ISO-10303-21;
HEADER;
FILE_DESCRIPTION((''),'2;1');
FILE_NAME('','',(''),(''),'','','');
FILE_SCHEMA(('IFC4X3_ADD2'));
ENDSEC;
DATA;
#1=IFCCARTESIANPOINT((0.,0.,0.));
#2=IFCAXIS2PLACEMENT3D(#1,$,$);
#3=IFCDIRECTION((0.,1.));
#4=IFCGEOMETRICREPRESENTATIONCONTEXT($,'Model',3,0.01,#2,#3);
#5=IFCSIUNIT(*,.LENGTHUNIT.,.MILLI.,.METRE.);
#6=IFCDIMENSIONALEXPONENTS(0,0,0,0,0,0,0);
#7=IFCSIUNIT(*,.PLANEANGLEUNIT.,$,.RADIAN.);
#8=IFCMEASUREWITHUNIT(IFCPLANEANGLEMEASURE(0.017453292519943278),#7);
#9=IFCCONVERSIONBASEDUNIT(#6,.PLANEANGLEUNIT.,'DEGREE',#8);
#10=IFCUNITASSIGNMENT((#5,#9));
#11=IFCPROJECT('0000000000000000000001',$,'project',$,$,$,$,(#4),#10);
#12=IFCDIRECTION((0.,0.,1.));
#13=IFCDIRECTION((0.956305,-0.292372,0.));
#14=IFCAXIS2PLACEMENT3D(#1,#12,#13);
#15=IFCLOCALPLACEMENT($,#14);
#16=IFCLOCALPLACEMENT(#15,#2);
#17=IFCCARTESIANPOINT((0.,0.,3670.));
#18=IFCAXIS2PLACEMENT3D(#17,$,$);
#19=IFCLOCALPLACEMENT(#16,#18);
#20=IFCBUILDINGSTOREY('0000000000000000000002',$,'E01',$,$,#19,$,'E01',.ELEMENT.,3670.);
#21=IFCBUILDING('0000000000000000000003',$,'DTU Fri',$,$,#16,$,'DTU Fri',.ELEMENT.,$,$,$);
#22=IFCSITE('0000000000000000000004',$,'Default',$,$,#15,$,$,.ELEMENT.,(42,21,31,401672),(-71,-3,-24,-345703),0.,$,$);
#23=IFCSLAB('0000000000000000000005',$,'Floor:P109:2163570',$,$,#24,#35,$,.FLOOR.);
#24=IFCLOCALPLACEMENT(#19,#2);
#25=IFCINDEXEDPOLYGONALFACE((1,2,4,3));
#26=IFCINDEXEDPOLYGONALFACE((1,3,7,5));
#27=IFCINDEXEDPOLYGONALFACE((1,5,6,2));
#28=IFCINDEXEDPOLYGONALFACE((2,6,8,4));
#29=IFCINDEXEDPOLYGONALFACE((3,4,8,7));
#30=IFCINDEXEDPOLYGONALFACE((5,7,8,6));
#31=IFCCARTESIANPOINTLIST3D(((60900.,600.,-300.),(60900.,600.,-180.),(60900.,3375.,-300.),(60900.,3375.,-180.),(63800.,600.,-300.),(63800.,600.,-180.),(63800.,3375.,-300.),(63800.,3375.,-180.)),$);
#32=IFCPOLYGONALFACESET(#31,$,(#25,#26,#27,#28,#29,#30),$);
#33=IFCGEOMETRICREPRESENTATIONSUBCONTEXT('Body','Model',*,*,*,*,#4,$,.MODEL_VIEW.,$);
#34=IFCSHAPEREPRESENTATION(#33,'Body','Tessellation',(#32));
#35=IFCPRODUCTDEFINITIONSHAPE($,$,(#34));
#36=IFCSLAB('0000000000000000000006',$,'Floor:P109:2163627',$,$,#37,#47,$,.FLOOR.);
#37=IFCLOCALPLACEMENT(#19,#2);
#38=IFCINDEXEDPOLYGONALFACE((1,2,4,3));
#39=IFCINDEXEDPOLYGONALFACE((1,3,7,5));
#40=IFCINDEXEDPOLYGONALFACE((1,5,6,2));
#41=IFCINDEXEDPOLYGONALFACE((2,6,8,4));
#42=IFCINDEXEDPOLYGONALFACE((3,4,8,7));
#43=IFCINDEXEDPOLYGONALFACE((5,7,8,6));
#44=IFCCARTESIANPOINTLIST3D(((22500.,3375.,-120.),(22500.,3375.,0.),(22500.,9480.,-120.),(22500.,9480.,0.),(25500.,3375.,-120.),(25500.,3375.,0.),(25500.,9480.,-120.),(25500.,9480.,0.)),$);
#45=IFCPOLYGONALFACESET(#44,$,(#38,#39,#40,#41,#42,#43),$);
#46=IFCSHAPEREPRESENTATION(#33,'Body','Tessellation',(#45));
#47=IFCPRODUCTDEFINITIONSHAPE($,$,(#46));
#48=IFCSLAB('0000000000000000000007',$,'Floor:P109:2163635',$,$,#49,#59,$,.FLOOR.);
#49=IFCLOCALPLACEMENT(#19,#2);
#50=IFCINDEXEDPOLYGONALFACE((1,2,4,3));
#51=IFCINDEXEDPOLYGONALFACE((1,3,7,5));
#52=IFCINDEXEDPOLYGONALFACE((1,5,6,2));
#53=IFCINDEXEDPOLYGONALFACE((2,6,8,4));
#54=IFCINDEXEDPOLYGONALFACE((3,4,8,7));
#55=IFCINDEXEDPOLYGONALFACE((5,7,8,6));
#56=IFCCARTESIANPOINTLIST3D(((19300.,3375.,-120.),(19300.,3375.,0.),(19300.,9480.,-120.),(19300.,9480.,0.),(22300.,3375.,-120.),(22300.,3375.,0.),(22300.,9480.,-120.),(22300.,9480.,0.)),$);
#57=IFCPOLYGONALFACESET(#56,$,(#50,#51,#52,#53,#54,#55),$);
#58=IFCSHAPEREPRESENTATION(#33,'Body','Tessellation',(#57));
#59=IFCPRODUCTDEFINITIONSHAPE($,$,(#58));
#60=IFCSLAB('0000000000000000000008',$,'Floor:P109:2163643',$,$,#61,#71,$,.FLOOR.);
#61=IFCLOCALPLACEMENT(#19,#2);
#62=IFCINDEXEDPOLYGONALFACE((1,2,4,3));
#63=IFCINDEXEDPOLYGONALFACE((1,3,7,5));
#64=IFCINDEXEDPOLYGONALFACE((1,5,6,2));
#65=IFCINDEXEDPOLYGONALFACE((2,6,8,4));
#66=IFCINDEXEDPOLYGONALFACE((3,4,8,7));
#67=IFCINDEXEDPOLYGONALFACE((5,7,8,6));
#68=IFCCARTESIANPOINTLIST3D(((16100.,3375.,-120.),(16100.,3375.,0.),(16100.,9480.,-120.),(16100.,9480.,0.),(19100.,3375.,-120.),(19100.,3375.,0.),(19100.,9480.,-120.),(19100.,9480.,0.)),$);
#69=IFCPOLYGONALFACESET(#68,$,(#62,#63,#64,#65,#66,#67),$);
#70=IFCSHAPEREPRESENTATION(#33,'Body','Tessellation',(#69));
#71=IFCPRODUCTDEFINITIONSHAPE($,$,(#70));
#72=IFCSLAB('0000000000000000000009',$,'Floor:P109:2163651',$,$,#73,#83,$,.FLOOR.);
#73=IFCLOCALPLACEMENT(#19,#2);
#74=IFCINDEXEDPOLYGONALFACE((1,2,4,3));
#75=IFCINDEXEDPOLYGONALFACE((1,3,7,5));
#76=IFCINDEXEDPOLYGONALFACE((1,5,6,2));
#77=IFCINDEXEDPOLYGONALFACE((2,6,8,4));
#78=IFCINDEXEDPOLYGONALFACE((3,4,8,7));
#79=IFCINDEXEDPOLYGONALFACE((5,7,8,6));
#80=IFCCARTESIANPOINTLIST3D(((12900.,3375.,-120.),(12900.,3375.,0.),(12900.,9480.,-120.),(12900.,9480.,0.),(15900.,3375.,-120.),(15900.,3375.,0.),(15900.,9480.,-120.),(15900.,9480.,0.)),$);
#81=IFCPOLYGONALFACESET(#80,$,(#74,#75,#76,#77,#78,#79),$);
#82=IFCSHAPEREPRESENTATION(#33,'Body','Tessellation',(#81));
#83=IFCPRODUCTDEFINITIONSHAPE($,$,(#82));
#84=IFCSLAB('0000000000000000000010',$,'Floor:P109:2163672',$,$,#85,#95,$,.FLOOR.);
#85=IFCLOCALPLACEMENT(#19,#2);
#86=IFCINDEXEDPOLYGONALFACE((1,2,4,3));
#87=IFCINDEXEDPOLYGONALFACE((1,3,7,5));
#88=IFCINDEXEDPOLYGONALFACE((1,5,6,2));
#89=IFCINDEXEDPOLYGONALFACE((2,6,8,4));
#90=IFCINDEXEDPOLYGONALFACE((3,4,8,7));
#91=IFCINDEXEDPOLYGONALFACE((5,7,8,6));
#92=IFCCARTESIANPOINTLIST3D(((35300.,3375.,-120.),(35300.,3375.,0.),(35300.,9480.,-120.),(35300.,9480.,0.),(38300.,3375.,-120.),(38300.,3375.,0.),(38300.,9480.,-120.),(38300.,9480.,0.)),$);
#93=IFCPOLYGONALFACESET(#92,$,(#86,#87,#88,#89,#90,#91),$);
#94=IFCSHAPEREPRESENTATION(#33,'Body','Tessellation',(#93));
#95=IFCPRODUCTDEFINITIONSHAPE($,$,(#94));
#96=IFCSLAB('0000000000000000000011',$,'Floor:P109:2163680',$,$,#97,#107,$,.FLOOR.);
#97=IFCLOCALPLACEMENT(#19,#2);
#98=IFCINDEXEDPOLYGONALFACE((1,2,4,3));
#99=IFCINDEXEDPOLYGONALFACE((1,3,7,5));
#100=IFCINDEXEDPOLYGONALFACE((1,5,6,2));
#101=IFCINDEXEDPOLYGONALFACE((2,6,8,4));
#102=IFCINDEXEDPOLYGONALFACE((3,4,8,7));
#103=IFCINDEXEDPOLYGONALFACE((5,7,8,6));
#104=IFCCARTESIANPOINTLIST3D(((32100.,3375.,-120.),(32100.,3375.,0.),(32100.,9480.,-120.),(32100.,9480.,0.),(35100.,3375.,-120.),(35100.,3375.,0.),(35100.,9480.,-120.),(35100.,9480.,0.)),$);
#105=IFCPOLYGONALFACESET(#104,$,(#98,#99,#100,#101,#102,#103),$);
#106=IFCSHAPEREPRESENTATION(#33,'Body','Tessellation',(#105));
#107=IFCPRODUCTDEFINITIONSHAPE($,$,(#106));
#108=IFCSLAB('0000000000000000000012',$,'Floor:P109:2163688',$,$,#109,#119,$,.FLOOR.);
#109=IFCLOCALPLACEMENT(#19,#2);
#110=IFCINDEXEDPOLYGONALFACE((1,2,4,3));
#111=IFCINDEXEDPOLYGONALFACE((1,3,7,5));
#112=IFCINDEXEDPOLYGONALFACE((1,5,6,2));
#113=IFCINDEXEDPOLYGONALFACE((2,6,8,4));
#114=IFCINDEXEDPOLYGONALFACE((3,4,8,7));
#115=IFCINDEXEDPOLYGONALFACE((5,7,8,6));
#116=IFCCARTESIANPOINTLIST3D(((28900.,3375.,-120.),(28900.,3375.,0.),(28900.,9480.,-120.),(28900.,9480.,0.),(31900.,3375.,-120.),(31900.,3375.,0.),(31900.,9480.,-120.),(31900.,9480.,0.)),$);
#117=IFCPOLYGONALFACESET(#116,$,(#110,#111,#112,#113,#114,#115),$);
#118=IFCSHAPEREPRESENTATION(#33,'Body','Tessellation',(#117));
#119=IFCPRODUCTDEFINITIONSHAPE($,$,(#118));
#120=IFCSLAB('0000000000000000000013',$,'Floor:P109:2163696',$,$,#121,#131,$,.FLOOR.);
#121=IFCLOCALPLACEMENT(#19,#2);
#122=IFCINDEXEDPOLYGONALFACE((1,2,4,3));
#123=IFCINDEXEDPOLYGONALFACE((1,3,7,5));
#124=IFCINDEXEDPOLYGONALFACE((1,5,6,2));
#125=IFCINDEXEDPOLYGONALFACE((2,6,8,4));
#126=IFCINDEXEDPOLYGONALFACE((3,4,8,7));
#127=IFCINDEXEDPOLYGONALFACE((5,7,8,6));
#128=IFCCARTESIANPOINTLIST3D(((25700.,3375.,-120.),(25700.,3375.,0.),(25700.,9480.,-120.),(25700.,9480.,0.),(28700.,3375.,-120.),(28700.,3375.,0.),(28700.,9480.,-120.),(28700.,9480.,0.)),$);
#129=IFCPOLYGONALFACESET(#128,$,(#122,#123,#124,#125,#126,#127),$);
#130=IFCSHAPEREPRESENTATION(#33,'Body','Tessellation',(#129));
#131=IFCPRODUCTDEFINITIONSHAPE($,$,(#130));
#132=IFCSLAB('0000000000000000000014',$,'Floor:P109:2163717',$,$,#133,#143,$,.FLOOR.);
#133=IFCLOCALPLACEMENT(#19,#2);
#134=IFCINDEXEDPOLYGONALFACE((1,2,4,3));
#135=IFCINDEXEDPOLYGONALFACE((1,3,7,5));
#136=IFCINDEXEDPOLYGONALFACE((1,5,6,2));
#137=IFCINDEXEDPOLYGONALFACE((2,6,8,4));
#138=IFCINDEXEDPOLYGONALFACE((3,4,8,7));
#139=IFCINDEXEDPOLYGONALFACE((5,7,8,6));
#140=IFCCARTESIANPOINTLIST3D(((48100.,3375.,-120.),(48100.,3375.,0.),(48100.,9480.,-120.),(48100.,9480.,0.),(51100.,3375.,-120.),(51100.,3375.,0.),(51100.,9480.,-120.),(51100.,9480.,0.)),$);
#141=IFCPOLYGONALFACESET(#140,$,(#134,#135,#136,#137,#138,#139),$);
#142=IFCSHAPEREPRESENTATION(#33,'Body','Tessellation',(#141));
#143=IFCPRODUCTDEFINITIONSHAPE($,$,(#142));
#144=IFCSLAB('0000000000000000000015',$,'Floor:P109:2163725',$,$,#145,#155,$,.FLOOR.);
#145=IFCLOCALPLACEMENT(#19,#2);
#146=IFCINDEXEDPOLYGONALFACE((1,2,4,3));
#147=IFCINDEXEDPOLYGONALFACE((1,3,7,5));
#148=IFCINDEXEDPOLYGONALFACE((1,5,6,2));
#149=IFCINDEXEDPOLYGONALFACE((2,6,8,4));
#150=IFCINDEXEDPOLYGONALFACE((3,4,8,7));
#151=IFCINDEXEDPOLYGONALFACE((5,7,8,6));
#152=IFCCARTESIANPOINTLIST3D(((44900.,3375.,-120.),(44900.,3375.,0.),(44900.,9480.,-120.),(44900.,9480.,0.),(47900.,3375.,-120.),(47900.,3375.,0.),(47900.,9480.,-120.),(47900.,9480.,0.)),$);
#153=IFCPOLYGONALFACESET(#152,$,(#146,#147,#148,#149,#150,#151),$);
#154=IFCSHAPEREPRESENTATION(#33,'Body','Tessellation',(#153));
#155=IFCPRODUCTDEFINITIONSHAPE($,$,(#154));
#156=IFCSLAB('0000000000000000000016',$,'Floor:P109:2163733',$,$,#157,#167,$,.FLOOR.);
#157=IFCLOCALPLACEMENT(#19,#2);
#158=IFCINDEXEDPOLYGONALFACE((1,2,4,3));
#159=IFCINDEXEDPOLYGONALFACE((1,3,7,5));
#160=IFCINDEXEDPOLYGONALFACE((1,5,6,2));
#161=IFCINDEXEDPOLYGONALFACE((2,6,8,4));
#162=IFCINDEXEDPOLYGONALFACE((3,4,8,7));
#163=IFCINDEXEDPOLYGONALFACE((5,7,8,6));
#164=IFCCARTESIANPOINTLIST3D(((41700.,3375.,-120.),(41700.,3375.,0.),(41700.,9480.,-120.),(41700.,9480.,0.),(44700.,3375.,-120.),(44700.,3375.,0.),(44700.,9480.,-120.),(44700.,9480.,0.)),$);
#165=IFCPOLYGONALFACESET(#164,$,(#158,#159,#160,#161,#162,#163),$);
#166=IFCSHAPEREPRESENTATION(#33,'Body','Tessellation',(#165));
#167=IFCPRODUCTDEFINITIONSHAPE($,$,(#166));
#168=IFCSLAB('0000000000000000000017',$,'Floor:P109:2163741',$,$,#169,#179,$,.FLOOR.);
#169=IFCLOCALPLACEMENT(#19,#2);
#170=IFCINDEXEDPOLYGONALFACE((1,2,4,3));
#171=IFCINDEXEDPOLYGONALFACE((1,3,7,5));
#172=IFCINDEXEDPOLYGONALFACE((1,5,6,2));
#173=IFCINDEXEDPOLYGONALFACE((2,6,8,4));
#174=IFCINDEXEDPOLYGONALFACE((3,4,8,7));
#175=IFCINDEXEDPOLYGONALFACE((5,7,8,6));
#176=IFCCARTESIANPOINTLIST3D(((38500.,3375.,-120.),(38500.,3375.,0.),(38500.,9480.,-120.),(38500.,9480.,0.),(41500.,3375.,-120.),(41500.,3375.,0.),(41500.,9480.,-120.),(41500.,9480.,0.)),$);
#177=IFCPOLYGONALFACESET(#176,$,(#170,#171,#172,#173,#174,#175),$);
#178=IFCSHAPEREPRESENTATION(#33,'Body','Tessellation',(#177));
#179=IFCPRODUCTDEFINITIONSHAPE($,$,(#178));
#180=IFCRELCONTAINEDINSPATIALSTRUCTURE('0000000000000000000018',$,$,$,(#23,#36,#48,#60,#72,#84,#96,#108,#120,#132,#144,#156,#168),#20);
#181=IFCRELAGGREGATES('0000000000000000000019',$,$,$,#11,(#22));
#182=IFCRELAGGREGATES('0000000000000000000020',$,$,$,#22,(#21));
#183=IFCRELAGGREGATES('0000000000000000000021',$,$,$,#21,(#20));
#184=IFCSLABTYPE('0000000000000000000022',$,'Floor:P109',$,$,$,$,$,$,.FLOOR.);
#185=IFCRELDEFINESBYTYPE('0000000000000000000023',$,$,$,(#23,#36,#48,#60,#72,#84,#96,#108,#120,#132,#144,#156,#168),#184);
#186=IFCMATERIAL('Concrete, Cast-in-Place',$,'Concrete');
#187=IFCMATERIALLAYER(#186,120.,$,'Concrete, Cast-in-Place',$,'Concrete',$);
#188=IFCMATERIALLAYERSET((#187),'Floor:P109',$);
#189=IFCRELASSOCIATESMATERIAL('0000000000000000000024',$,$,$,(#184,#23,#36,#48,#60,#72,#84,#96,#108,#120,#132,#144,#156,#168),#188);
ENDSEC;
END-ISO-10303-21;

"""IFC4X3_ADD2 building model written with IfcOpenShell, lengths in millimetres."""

from ifc_helpers import new_model, entity, si_unit, converted_unit, direction, frame, frame_2d, origin, origin_2d_with_axis, place, context, subcontext, project, spatial, rectangle, extrude, material, layer, layer_set, layer_usage, type_object, element, save


model = new_model("IFC4X3_ADD2")

# Units and contexts
model_context = context("Model", 3, precision=0.01, world=origin(), true_north=direction((0.0, 1.0)))
body_context = subcontext(model_context, "Body", "Model", "MODEL_VIEW")
ifc_project = project(units=[si_unit("LENGTHUNIT", "METRE", prefix="MILLI"), converted_unit("PLANEANGLEUNIT", "DEGREE", entity("IfcPlaneAngleMeasure", 0.017453292519943278), si_unit("PLANEANGLEUNIT", "RADIAN"), dimensions=[0, 0, 0, 0, 0, 0, 0])], contexts=[model_context])

# Site, building, storey
site_placement = place(None, frame((0.0, 0.0, 0.0), z_axis=(0.0, 0.0, 1.0), x_axis=(0.956305, -0.292372, 0.0)))
site = spatial("IfcSite", under=ifc_project, at=site_placement, Name="Default", CompositionType="ELEMENT", RefLatitude=(42, 21, 31, 401672), RefLongitude=(-71, -3, -24, -345703), RefElevation=0.0)
building_placement = place(site_placement, origin())
building = spatial("IfcBuilding", under=site, at=building_placement, Name="DTU Fri", LongName="DTU Fri", CompositionType="ELEMENT")
storey_placement = place(building_placement, frame((0.0, 0.0, 3670.0)))
storey = spatial("IfcBuildingStorey", under=building, at=storey_placement, Name="E01", LongName="E01", CompositionType="ELEMENT", Elevation=3670.0)

# Slabs
ifc_material = material(Name="Concrete, Cast-in-Place", Category="Concrete")
ifc_layer_1 = layer(ifc_material, 120.0, Name="Concrete, Cast-in-Place", Category="Concrete")
ifc_layer_set_1 = layer_set([ifc_layer_1], Name="Floor:P109")
slab_type_1 = type_object("IfcSlabType", Name="Floor:P109", PredefinedType="FLOOR", material=ifc_layer_set_1)
ifc_layer_usage_1 = layer_usage(ifc_layer_set_1, "AXIS3", "POSITIVE", 0.0)
slab_1_placement = place(storey_placement, origin())
element("IfcSlab", 1, at=slab_1_placement, inside=storey, type_object=slab_type_1, material=ifc_layer_usage_1, Name="Floor:P109:2163570", PredefinedType="FLOOR", context=body_context, shape_type="SweptSolid", body=[
    extrude(rectangle(XDim=2775.0, YDim=2900.0, at=frame_2d((0.0, 0.0), x_axis=(1.0, 0.0))), frame((62350.0, 1987.5, -180.0), z_axis=(0.0, 0.0, -1.0), x_axis=(0.0, 1.0, 0.0)), (0.0, 0.0, 1.0), 120.0),
])
ifc_layer_usage_2 = layer_usage(ifc_layer_set_1, "AXIS3", "POSITIVE", 0.0)
slab_2_placement = place(storey_placement, origin())
element("IfcSlab", 2, at=slab_2_placement, inside=storey, type_object=slab_type_1, material=ifc_layer_usage_2, Name="Floor:P109:2163627", PredefinedType="FLOOR", context=body_context, shape_type="SweptSolid", body=[
    extrude(rectangle(XDim=6105.0, YDim=3000.0, at=frame_2d((0.0, 0.0), x_axis=(1.0, 0.0))), frame((24000.0, 6427.5, 0.0), z_axis=(0.0, 0.0, -1.0), x_axis=(0.0, 1.0, 0.0)), (0.0, 0.0, 1.0), 120.0),
])
ifc_layer_usage_3 = layer_usage(ifc_layer_set_1, "AXIS3", "POSITIVE", 0.0)
slab_3_placement = place(storey_placement, origin())
element("IfcSlab", 3, at=slab_3_placement, inside=storey, type_object=slab_type_1, material=ifc_layer_usage_3, Name="Floor:P109:2163635", PredefinedType="FLOOR", context=body_context, shape_type="SweptSolid", body=[
    extrude(rectangle(XDim=6105.0, YDim=3000.0, at=frame_2d((0.0, 0.0), x_axis=(1.0, 0.0))), frame((20800.0, 6427.5, 0.0), z_axis=(0.0, 0.0, -1.0), x_axis=(0.0, 1.0, 0.0)), (0.0, 0.0, 1.0), 120.0),
])
ifc_layer_usage_4 = layer_usage(ifc_layer_set_1, "AXIS3", "POSITIVE", 0.0)
slab_4_placement = place(storey_placement, origin())
element("IfcSlab", 4, at=slab_4_placement, inside=storey, type_object=slab_type_1, material=ifc_layer_usage_4, Name="Floor:P109:2163643", PredefinedType="FLOOR", context=body_context, shape_type="SweptSolid", body=[
    extrude(rectangle(XDim=6105.0, YDim=3000.0, at=frame_2d((0.0, 0.0), x_axis=(1.0, 0.0))), frame((17600.0, 6427.5, 0.0), z_axis=(0.0, 0.0, -1.0), x_axis=(0.0, 1.0, 0.0)), (0.0, 0.0, 1.0), 120.0),
])
ifc_layer_usage_5 = layer_usage(ifc_layer_set_1, "AXIS3", "POSITIVE", 0.0)
slab_5_placement = place(storey_placement, origin())
element("IfcSlab", 5, at=slab_5_placement, inside=storey, type_object=slab_type_1, material=ifc_layer_usage_5, Name="Floor:P109:2163651", PredefinedType="FLOOR", context=body_context, shape_type="SweptSolid", body=[
    extrude(rectangle(XDim=6105.0, YDim=3000.0, at=frame_2d((0.0, 0.0), x_axis=(1.0, 0.0))), frame((14400.0, 6427.5, 0.0), z_axis=(0.0, 0.0, -1.0), x_axis=(0.0, 1.0, 0.0)), (0.0, 0.0, 1.0), 120.0),
])
ifc_layer_usage_6 = layer_usage(ifc_layer_set_1, "AXIS3", "POSITIVE", 0.0)
slab_6_placement = place(storey_placement, origin())
element("IfcSlab", 6, at=slab_6_placement, inside=storey, type_object=slab_type_1, material=ifc_layer_usage_6, Name="Floor:P109:2163672", PredefinedType="FLOOR", context=body_context, shape_type="SweptSolid", body=[
    extrude(rectangle(XDim=6105.0, YDim=3000.0, at=frame_2d((0.0, 0.0), x_axis=(1.0, 0.0))), frame((36800.0, 6427.5, 0.0), z_axis=(0.0, 0.0, -1.0), x_axis=(0.0, 1.0, 0.0)), (0.0, 0.0, 1.0), 120.0),
])
ifc_layer_usage_7 = layer_usage(ifc_layer_set_1, "AXIS3", "POSITIVE", 0.0)
slab_7_placement = place(storey_placement, origin())
element("IfcSlab", 7, at=slab_7_placement, inside=storey, type_object=slab_type_1, material=ifc_layer_usage_7, Name="Floor:P109:2163680", PredefinedType="FLOOR", context=body_context, shape_type="SweptSolid", body=[
    extrude(rectangle(XDim=6105.0, YDim=3000.0, at=frame_2d((0.0, 0.0), x_axis=(1.0, 0.0))), frame((33600.0, 6427.5, 0.0), z_axis=(0.0, 0.0, -1.0), x_axis=(0.0, 1.0, 0.0)), (0.0, 0.0, 1.0), 120.0),
])
ifc_layer_usage_8 = layer_usage(ifc_layer_set_1, "AXIS3", "POSITIVE", 0.0)
slab_8_placement = place(storey_placement, origin())
element("IfcSlab", 8, at=slab_8_placement, inside=storey, type_object=slab_type_1, material=ifc_layer_usage_8, Name="Floor:P109:2163688", PredefinedType="FLOOR", context=body_context, shape_type="SweptSolid", body=[
    extrude(rectangle(XDim=6105.0, YDim=3000.0, at=frame_2d((0.0, 0.0), x_axis=(1.0, 0.0))), frame((30400.0, 6427.5, 0.0), z_axis=(0.0, 0.0, -1.0), x_axis=(0.0, 1.0, 0.0)), (0.0, 0.0, 1.0), 120.0),
])
ifc_layer_usage_9 = layer_usage(ifc_layer_set_1, "AXIS3", "POSITIVE", 0.0)
slab_9_placement = place(storey_placement, origin())
element("IfcSlab", 9, at=slab_9_placement, inside=storey, type_object=slab_type_1, material=ifc_layer_usage_9, Name="Floor:P109:2163696", PredefinedType="FLOOR", context=body_context, shape_type="SweptSolid", body=[
    extrude(rectangle(XDim=6105.0, YDim=3000.0, at=frame_2d((0.0, 0.0), x_axis=(1.0, 0.0))), frame((27200.0, 6427.5, 0.0), z_axis=(0.0, 0.0, -1.0), x_axis=(0.0, 1.0, 0.0)), (0.0, 0.0, 1.0), 120.0),
])
ifc_layer_usage_10 = layer_usage(ifc_layer_set_1, "AXIS3", "POSITIVE", 0.0)
slab_10_placement = place(storey_placement, origin())
element("IfcSlab", 10, at=slab_10_placement, inside=storey, type_object=slab_type_1, material=ifc_layer_usage_10, Name="Floor:P109:2163717", PredefinedType="FLOOR", context=body_context, shape_type="SweptSolid", body=[
    extrude(rectangle(XDim=6105.0, YDim=3000.0, at=frame_2d((0.0, 0.0), x_axis=(1.0, 0.0))), frame((49600.0, 6427.5, 0.0), z_axis=(0.0, 0.0, -1.0), x_axis=(0.0, 1.0, 0.0)), (0.0, 0.0, 1.0), 120.0),
])
ifc_layer_usage_11 = layer_usage(ifc_layer_set_1, "AXIS3", "POSITIVE", 0.0)
slab_11_placement = place(storey_placement, origin())
element("IfcSlab", 11, at=slab_11_placement, inside=storey, type_object=slab_type_1, material=ifc_layer_usage_11, Name="Floor:P109:2163725", PredefinedType="FLOOR", context=body_context, shape_type="SweptSolid", body=[
    extrude(rectangle(XDim=6105.0, YDim=3000.0, at=origin_2d_with_axis()), frame((46400.0, 6427.5, 0.0), z_axis=(0.0, 0.0, -1.0), x_axis=(0.0, 1.0, 0.0)), (0.0, 0.0, 1.0), 120.0),
])
ifc_layer_usage_12 = layer_usage(ifc_layer_set_1, "AXIS3", "POSITIVE", 0.0)
slab_12_placement = place(storey_placement, origin())
element("IfcSlab", 12, at=slab_12_placement, inside=storey, type_object=slab_type_1, material=ifc_layer_usage_12, Name="Floor:P109:2163733", PredefinedType="FLOOR", context=body_context, shape_type="SweptSolid", body=[
    extrude(rectangle(XDim=6105.0, YDim=3000.0, at=frame_2d((0.0, 0.0), x_axis=(1.0, 0.0))), frame((43200.0, 6427.5, 0.0), z_axis=(0.0, 0.0, -1.0), x_axis=(0.0, 1.0, 0.0)), (0.0, 0.0, 1.0), 120.0),
])
ifc_layer_usage_13 = layer_usage(ifc_layer_set_1, "AXIS3", "POSITIVE", 0.0)
slab_13_placement = place(storey_placement, origin())
element("IfcSlab", 13, at=slab_13_placement, inside=storey, type_object=slab_type_1, material=ifc_layer_usage_13, Name="Floor:P109:2163741", PredefinedType="FLOOR", context=body_context, shape_type="SweptSolid", body=[
    extrude(rectangle(XDim=6105.0, YDim=3000.0, at=frame_2d((0.0, 0.0), x_axis=(1.0, 0.0))), frame((40000.0, 6427.5, 0.0), z_axis=(0.0, 0.0, -1.0), x_axis=(0.0, 1.0, 0.0)), (0.0, 0.0, 1.0), 120.0),
])

save(model, "model.ifc")
